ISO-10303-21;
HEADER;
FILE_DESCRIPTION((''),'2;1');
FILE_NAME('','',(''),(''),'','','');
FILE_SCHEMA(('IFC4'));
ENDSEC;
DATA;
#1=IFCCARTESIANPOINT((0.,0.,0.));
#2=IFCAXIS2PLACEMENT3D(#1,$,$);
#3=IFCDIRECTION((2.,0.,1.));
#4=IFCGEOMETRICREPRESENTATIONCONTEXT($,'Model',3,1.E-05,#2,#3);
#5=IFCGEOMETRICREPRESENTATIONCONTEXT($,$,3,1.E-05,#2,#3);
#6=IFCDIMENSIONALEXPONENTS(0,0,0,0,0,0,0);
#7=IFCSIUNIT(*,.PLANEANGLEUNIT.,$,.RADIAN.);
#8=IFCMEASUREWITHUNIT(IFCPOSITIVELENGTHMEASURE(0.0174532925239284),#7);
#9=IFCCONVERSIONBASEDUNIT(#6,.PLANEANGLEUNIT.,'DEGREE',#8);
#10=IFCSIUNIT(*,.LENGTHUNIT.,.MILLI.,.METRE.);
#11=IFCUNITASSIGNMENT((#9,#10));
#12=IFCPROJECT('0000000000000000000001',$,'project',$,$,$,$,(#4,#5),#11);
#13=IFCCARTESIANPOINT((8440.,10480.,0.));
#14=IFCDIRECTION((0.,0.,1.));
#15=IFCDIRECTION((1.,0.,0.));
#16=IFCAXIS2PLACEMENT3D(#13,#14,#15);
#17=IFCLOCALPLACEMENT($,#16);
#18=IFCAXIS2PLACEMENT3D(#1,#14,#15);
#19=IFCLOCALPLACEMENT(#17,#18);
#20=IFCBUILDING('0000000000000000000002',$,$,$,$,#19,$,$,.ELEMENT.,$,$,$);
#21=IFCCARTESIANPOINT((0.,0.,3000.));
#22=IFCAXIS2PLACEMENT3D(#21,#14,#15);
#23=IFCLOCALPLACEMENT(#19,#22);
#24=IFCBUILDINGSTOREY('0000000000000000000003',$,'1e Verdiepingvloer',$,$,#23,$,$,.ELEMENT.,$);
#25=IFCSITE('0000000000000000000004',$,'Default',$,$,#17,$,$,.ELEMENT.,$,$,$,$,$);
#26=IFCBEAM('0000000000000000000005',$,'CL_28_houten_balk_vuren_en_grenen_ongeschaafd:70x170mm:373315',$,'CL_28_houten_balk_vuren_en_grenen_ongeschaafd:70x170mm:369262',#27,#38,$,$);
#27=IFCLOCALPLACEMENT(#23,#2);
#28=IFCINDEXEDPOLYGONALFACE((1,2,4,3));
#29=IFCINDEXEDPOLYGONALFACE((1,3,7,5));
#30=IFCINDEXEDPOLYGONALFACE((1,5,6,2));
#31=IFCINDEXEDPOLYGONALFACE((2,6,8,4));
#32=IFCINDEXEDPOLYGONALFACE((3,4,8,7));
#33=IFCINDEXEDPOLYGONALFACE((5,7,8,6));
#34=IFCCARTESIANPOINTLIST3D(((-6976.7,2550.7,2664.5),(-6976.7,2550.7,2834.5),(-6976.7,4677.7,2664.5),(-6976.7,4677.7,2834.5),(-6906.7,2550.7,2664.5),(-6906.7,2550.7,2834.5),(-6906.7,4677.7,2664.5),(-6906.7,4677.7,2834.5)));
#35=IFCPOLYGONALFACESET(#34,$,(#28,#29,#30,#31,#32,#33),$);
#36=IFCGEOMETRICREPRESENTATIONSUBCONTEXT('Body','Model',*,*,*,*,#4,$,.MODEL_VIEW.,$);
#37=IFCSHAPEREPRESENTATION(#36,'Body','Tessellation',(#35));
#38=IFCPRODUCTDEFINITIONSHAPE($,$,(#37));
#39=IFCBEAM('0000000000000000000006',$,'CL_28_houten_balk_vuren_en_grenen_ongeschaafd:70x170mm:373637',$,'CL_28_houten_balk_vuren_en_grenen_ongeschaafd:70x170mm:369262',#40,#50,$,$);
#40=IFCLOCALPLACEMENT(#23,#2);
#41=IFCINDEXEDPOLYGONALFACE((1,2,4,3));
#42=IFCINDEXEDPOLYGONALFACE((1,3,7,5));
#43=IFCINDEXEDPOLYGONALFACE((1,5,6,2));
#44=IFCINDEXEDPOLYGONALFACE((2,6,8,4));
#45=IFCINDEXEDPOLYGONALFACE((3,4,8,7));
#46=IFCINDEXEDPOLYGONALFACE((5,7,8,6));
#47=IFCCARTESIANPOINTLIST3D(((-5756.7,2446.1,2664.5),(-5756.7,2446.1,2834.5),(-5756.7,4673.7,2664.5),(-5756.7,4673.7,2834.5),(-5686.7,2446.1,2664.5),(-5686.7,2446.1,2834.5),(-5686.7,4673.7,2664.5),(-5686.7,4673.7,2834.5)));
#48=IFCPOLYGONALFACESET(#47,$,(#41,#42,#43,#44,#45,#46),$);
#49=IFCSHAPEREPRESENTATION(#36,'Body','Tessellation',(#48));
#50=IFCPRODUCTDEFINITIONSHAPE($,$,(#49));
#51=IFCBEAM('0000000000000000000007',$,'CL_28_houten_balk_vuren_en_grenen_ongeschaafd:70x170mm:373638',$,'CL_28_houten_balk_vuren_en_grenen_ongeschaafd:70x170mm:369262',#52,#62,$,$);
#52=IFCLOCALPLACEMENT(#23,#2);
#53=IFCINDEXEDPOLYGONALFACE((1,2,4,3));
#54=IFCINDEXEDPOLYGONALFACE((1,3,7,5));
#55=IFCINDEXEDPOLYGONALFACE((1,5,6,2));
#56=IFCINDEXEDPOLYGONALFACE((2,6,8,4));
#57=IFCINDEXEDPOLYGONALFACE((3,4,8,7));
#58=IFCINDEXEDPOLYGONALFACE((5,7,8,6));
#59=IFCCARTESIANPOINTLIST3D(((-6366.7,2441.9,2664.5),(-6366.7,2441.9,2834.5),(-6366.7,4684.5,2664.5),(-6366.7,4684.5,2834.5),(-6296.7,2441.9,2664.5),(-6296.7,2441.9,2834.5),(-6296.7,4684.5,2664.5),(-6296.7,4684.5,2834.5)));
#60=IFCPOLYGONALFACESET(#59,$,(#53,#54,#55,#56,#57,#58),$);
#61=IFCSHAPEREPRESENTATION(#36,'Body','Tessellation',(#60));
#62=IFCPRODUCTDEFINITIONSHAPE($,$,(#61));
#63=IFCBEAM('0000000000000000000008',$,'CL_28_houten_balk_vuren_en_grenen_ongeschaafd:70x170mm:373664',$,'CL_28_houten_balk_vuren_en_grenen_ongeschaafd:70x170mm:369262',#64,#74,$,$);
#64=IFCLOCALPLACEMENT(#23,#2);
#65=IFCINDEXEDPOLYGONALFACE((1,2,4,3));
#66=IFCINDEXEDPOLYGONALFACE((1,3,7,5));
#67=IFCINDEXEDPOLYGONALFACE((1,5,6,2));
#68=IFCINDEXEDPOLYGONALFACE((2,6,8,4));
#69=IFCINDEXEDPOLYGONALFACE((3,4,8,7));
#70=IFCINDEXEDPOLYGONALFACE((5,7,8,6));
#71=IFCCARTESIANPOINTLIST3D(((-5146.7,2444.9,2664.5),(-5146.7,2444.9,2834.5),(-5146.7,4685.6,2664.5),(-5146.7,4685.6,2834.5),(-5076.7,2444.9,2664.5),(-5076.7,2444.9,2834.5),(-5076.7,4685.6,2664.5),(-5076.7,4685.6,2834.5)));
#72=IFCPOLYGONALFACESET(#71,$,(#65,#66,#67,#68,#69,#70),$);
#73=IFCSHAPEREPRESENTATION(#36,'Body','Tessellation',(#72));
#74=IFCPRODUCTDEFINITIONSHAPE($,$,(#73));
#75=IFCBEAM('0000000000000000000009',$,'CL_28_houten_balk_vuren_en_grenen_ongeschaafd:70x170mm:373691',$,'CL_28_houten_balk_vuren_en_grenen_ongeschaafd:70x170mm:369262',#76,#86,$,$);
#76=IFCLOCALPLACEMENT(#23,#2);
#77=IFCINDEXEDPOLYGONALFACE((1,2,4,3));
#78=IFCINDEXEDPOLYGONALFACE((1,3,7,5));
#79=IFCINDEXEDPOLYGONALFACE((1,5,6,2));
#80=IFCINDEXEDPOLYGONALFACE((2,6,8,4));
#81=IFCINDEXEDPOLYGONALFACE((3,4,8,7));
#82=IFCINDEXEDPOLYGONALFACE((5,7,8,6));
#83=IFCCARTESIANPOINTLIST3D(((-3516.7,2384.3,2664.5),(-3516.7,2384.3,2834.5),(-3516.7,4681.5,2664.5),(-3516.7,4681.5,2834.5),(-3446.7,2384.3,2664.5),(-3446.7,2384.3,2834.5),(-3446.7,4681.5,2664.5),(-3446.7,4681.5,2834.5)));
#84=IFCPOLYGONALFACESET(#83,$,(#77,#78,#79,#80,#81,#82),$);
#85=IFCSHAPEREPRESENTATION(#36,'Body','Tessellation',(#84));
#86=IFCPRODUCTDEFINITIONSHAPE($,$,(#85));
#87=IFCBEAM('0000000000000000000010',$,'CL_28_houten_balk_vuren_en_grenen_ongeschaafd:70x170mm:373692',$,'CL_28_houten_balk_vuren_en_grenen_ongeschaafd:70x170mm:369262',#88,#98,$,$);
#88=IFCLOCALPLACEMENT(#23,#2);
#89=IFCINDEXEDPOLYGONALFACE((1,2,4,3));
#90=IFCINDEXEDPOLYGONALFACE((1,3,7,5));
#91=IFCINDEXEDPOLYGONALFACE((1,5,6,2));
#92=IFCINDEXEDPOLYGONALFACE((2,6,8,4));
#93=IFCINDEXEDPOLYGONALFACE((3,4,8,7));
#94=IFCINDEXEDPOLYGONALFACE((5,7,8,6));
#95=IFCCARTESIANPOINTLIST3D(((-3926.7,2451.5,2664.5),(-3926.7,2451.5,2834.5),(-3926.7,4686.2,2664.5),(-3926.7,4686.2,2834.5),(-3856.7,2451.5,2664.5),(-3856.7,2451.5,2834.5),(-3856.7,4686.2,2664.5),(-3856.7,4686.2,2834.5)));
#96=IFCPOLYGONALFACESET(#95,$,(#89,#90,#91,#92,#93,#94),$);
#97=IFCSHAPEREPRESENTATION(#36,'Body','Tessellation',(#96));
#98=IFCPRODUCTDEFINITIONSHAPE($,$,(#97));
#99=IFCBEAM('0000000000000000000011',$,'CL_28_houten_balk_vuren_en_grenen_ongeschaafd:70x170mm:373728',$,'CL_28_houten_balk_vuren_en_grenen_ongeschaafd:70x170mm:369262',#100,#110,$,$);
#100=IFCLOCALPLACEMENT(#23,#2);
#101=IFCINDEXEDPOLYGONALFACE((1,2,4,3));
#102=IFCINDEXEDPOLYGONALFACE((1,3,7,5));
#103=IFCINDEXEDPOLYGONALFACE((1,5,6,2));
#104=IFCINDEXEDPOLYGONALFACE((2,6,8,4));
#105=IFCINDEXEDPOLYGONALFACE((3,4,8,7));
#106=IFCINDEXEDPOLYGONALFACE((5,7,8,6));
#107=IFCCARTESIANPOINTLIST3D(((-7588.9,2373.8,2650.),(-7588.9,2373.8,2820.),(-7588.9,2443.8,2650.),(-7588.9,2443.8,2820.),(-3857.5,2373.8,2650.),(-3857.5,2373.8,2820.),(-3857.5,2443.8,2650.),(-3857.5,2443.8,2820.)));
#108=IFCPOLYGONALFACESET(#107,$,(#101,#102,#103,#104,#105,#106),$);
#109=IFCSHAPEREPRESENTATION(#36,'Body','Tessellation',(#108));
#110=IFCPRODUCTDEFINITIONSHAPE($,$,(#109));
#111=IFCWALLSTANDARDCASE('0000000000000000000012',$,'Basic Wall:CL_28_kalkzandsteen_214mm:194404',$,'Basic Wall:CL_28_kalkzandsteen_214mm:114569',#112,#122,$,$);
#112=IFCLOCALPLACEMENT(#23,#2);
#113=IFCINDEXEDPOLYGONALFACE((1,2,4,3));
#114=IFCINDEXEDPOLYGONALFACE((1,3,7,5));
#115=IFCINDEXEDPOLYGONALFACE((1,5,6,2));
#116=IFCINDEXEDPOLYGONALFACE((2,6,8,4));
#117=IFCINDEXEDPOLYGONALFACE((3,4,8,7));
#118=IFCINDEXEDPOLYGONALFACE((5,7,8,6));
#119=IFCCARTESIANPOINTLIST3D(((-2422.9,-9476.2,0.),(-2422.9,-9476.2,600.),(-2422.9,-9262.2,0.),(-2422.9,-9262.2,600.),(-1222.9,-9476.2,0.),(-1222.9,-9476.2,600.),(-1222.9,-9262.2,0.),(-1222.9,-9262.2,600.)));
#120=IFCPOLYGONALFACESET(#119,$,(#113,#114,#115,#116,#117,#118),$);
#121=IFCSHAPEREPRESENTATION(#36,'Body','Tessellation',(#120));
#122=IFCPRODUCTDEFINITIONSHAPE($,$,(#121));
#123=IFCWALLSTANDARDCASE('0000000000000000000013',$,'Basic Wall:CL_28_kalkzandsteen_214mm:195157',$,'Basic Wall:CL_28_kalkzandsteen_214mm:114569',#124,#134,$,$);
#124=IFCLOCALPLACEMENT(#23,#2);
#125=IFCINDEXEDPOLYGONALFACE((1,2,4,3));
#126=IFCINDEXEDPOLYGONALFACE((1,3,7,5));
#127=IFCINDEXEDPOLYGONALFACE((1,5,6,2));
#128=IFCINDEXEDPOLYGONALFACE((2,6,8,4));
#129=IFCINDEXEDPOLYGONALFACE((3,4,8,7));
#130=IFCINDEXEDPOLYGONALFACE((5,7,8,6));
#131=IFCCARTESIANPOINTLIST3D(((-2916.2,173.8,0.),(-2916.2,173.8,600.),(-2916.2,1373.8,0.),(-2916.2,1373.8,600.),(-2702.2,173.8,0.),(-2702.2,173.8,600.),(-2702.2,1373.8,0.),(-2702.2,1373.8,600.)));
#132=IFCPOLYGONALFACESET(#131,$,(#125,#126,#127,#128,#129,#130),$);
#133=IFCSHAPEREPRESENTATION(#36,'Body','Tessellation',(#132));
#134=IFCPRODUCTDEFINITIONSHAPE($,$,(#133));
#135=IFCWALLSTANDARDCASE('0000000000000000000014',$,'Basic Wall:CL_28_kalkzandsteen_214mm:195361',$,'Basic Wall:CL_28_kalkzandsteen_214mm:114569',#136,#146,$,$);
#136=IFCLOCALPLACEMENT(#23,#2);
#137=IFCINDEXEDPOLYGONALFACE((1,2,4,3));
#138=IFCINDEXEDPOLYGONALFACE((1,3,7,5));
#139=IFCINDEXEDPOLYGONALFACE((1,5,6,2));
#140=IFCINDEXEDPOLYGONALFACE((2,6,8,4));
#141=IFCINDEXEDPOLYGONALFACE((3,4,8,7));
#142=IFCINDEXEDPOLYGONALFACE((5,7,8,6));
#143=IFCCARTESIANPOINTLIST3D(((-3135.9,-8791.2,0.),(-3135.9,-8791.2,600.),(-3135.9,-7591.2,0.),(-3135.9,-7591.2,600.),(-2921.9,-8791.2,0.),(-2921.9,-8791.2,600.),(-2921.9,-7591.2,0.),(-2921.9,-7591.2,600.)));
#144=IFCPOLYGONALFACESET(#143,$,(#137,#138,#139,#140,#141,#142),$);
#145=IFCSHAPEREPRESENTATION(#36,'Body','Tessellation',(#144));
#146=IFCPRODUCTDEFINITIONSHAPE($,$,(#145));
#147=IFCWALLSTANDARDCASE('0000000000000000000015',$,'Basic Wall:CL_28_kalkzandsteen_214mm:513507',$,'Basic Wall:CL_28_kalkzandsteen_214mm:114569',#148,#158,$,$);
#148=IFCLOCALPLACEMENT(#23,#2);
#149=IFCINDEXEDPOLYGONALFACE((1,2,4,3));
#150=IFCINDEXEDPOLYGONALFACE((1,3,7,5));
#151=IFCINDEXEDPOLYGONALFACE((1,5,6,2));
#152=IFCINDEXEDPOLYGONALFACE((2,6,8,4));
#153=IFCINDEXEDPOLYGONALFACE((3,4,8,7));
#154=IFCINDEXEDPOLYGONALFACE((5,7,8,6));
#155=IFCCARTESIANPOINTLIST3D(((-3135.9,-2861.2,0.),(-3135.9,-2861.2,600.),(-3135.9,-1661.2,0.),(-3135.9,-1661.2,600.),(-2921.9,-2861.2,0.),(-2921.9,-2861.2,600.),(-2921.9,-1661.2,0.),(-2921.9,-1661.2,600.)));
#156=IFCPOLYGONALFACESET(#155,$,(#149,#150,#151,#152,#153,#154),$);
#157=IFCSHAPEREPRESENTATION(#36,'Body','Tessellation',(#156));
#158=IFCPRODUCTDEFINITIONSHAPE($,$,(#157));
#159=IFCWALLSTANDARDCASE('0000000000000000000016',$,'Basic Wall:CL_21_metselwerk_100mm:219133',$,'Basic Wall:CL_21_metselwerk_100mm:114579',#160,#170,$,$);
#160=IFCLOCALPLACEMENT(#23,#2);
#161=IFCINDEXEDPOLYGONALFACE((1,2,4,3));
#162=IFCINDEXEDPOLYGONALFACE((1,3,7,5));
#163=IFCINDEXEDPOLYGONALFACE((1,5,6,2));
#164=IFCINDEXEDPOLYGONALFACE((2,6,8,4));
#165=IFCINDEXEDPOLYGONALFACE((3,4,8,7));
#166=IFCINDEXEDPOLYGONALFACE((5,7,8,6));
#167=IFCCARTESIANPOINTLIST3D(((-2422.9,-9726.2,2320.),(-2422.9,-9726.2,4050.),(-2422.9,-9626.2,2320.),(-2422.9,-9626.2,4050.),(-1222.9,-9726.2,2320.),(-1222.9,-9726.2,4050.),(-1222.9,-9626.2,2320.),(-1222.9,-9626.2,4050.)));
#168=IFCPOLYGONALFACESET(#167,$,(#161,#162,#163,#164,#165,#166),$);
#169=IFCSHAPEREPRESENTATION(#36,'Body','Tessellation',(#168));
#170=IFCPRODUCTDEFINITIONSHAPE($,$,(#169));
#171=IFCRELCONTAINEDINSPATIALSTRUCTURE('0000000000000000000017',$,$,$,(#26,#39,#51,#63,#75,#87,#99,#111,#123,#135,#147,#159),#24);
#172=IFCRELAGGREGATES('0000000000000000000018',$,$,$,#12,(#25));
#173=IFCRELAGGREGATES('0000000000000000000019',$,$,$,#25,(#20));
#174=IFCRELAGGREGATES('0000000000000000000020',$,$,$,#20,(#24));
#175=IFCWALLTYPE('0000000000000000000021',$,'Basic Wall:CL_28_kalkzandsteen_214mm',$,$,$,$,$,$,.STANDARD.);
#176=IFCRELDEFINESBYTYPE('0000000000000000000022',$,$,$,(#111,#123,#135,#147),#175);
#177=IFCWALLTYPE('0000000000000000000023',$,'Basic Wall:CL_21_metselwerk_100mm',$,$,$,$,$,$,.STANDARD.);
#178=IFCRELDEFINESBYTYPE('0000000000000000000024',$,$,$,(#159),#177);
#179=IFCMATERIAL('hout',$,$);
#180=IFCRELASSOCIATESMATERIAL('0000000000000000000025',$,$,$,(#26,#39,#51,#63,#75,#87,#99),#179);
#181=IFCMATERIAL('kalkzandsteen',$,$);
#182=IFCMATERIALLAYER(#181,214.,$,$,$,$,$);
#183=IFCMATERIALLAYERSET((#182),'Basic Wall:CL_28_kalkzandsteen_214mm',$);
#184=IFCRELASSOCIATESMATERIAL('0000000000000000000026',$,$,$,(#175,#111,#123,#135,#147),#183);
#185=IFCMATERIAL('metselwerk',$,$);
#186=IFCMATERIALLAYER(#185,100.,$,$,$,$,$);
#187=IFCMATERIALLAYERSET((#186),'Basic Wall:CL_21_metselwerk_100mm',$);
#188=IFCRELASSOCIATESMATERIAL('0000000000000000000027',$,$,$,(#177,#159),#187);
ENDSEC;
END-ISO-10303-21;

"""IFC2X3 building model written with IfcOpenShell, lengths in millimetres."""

from ifc_helpers import new_model, entity, si_unit, converted_unit, direction, frame, frame_2d, origin, origin_with_axes, place, context, subcontext, project, spatial, rectangle, extrude, source, transform, mapped, material, layer, layer_set, layer_usage, type_object, element, save


model = new_model("IFC2X3")

# Units and contexts
model_context = context("Model", 3, precision=1e-05, world=origin(), true_north=direction((2.0, 0.0, 1.0)))
context_of_model = context(None, 3, precision=1e-05, world=origin(), true_north=direction((2.0, 0.0, 1.0)))
body_context = subcontext(model_context, "Body", "Model", "MODEL_VIEW")
ifc_project = project(units=[converted_unit("PLANEANGLEUNIT", "DEGREE", entity("IfcPositiveLengthMeasure", 0.0174532925239284), si_unit("PLANEANGLEUNIT", "RADIAN"), dimensions=[0, 0, 0, 0, 0, 0, 0]), si_unit("LENGTHUNIT", "METRE", prefix="MILLI")], contexts=[model_context, context_of_model])

# Site, building, storey
site_placement = place(None, frame((8440.0, 10480.0, 0.0), z_axis=(0.0, 0.0, 1.0), x_axis=(1.0, 0.0, 0.0)))
site = spatial("IfcSite", under=ifc_project, at=site_placement, Name="Default", CompositionType="ELEMENT")
building_placement = place(site_placement, origin_with_axes())
building = spatial("IfcBuilding", under=site, at=building_placement, CompositionType="ELEMENT")
storey_placement = place(building_placement, frame((0.0, 0.0, 3000.0), z_axis=(0.0, 0.0, 1.0), x_axis=(1.0, 0.0, 0.0)))
storey = spatial("IfcBuildingStorey", under=building, at=storey_placement, Name="1e Verdiepingvloer", CompositionType="ELEMENT")

# Beams
ifc_material_1 = material(Name="hout")
beam_1_placement = place(storey_placement, frame((-6941.7, 2480.8, 2834.5), z_axis=(0.0, 0.0, 1.0), x_axis=(0.0, 1.0, 0.0)))
element("IfcBeam", 1, at=beam_1_placement, inside=storey, material=ifc_material_1, Name="CL_28_houten_balk_vuren_en_grenen_ongeschaafd:70x170mm:373315", ObjectType="CL_28_houten_balk_vuren_en_grenen_ongeschaafd:70x170mm:369262", context=body_context, shape_type="SweptSolid", body=[
    extrude(rectangle(XDim=170.0, YDim=70.0, at=frame_2d((0.0, 0.0), x_axis=(1.0, 0.0))), frame((69.9, 0.0, -85.0), z_axis=(1.0, 0.0, 0.0), x_axis=(0.0, 0.0, -1.0)), (0.0, 0.0, 1.0), 2127.0),
])
beam_2_placement = place(storey_placement, frame((-5721.7, 2480.8, 2834.5), z_axis=(0.0, 0.0, 1.0), x_axis=(0.0, 1.0, 0.0)))
element("IfcBeam", 2, at=beam_2_placement, inside=storey, material=ifc_material_1, Name="CL_28_houten_balk_vuren_en_grenen_ongeschaafd:70x170mm:373637", ObjectType="CL_28_houten_balk_vuren_en_grenen_ongeschaafd:70x170mm:369262", context=body_context, shape_type="SweptSolid", body=[
    extrude(rectangle(XDim=170.0, YDim=70.0, at=frame_2d((0.0, 0.0), x_axis=(1.0, 0.0))), frame((-34.7, 0.0, -85.0), z_axis=(1.0, 0.0, 0.0), x_axis=(0.0, 0.0, -1.0)), (0.0, 0.0, 1.0), 2227.7),
])
beam_3_placement = place(storey_placement, frame((-6331.7, 2480.8, 2834.5), z_axis=(0.0, 0.0, 1.0), x_axis=(0.0, 1.0, 0.0)))
element("IfcBeam", 3, at=beam_3_placement, inside=storey, material=ifc_material_1, Name="CL_28_houten_balk_vuren_en_grenen_ongeschaafd:70x170mm:373638", ObjectType="CL_28_houten_balk_vuren_en_grenen_ongeschaafd:70x170mm:369262", context=body_context, shape_type="SweptSolid", body=[
    extrude(rectangle(XDim=170.0, YDim=70.0, at=frame_2d((0.0, 0.0), x_axis=(1.0, 0.0))), frame((-38.9, 0.0, -85.0), z_axis=(1.0, 0.0, 0.0), x_axis=(0.0, 0.0, -1.0)), (0.0, 0.0, 1.0), 2242.6),
])
beam_4_placement = place(storey_placement, frame((-5111.7, 2480.8, 2834.5), z_axis=(0.0, 0.0, 1.0), x_axis=(0.0, 1.0, 0.0)))
element("IfcBeam", 4, at=beam_4_placement, inside=storey, material=ifc_material_1, Name="CL_28_houten_balk_vuren_en_grenen_ongeschaafd:70x170mm:373664", ObjectType="CL_28_houten_balk_vuren_en_grenen_ongeschaafd:70x170mm:369262", context=body_context, shape_type="SweptSolid", body=[
    extrude(rectangle(XDim=170.0, YDim=70.0, at=frame_2d((0.0, 0.0), x_axis=(1.0, 0.0))), frame((-35.9, 0.0, -85.0), z_axis=(1.0, 0.0, 0.0), x_axis=(0.0, 0.0, -1.0)), (0.0, 0.0, 1.0), 2240.7),
])
beam_5_placement = place(storey_placement, frame((-3481.7, 2373.8, 2834.5), z_axis=(0.0, 0.0, 1.0), x_axis=(0.0, 1.0, 0.0)))
element("IfcBeam", 5, at=beam_5_placement, inside=storey, material=ifc_material_1, Name="CL_28_houten_balk_vuren_en_grenen_ongeschaafd:70x170mm:373691", ObjectType="CL_28_houten_balk_vuren_en_grenen_ongeschaafd:70x170mm:369262", context=body_context, shape_type="SweptSolid", body=[
    extrude(rectangle(XDim=170.0, YDim=70.0, at=frame_2d((0.0, 0.0), x_axis=(1.0, 0.0))), frame((10.5, 0.0, -85.0), z_axis=(1.0, 0.0, 0.0), x_axis=(0.0, 0.0, -1.0)), (0.0, 0.0, 1.0), 2297.2),
])
beam_6_placement = place(storey_placement, frame((-3891.7, 2441.0, 2834.5), z_axis=(0.0, 0.0, 1.0), x_axis=(0.0, 1.0, 0.0)))
element("IfcBeam", 6, at=beam_6_placement, inside=storey, material=ifc_material_1, Name="CL_28_houten_balk_vuren_en_grenen_ongeschaafd:70x170mm:373692", ObjectType="CL_28_houten_balk_vuren_en_grenen_ongeschaafd:70x170mm:369262", context=body_context, shape_type="SweptSolid", body=[
    extrude(rectangle(XDim=170.0, YDim=70.0, at=frame_2d((0.0, 0.0), x_axis=(1.0, 0.0))), frame((10.5, 0.0, -85.0), z_axis=(1.0, 0.0, 0.0), x_axis=(0.0, 0.0, -1.0)), (0.0, 0.0, 1.0), 2234.7),
])
beam_7_placement = place(storey_placement, frame((-7148.9, 2408.8, 2820.0), z_axis=(0.0, 0.0, 1.0), x_axis=(1.0, 0.0, 0.0)))
element("IfcBeam", 7, at=beam_7_placement, inside=storey, material=ifc_material_1, Name="CL_28_houten_balk_vuren_en_grenen_ongeschaafd:70x170mm:373728", ObjectType="CL_28_houten_balk_vuren_en_grenen_ongeschaafd:70x170mm:369262", context=body_context, shape_type="SweptSolid", body=[
    extrude(rectangle(XDim=170.0, YDim=70.0, at=frame_2d((0.0, 0.0), x_axis=(1.0, 0.0))), frame((-440.0, 0.0, -85.0), z_axis=(1.0, 0.0, 0.0), x_axis=(0.0, 0.0, -1.0)), (0.0, 0.0, 1.0), 3731.4),
])

# Walls
ifc_material_2 = material(Name="kalkzandsteen")
ifc_layer_1 = layer(ifc_material_2, 214.0)
ifc_layer_set_1 = layer_set([ifc_layer_1], Name="Basic Wall:CL_28_kalkzandsteen_214mm")
ifc_layer_usage_1 = layer_usage(ifc_layer_set_1, "AXIS2", "NEGATIVE", 107.0)
wall_type_1 = type_object("IfcWallType", Name="Basic Wall:CL_28_kalkzandsteen_214mm", PredefinedType="STANDARD", material=ifc_layer_set_1)
shared_shape_1 = source(origin(), body_context, "Body", "SweptSolid", [
    extrude(rectangle(XDim=1200.0, YDim=214.0, at=frame_2d((600.0, 0.0), x_axis=(-1.0, 0.0))), origin(), (0.0, 0.0, 1.0), 600.0),
])
wall_1_placement = place(storey_placement, frame((-2422.9, -9369.2, 0.0), z_axis=(0.0, 0.0, 1.0), x_axis=(1.0, 0.0, 0.0)))
element("IfcWallStandardCase", 8, at=wall_1_placement, inside=storey, type_object=wall_type_1, material=ifc_layer_usage_1, Name="Basic Wall:CL_28_kalkzandsteen_214mm:194404", ObjectType="Basic Wall:CL_28_kalkzandsteen_214mm:114569", context=body_context, shape_type="MappedRepresentation", body=[
    mapped(shared_shape_1, transform((0.0, 0.0, 0.0))),
])
ifc_layer_usage_2 = layer_usage(ifc_layer_set_1, "AXIS2", "NEGATIVE", 107.0)
wall_2_placement = place(storey_placement, frame((-2809.2, 1373.8, 0.0), z_axis=(0.0, 0.0, 1.0), x_axis=(0.0, -1.0, 0.0)))
element("IfcWallStandardCase", 9, at=wall_2_placement, inside=storey, type_object=wall_type_1, material=ifc_layer_usage_2, Name="Basic Wall:CL_28_kalkzandsteen_214mm:195157", ObjectType="Basic Wall:CL_28_kalkzandsteen_214mm:114569", context=body_context, shape_type="MappedRepresentation", body=[
    mapped(shared_shape_1, transform((0.0, 0.0, 0.0))),
])
ifc_layer_usage_3 = layer_usage(ifc_layer_set_1, "AXIS2", "NEGATIVE", 107.0)
wall_3_placement = place(storey_placement, frame((-3028.9, -7591.2, 0.0), z_axis=(0.0, 0.0, 1.0), x_axis=(0.0, -1.0, 0.0)))
element("IfcWallStandardCase", 10, at=wall_3_placement, inside=storey, type_object=wall_type_1, material=ifc_layer_usage_3, Name="Basic Wall:CL_28_kalkzandsteen_214mm:195361", ObjectType="Basic Wall:CL_28_kalkzandsteen_214mm:114569", context=body_context, shape_type="MappedRepresentation", body=[
    mapped(shared_shape_1, transform((0.0, 0.0, 0.0))),
])
ifc_layer_usage_4 = layer_usage(ifc_layer_set_1, "AXIS2", "NEGATIVE", 107.0)
wall_4_placement = place(storey_placement, frame((-3028.9, -1661.2, 0.0), z_axis=(0.0, 0.0, 1.0), x_axis=(0.0, -1.0, 0.0)))
element("IfcWallStandardCase", 11, at=wall_4_placement, inside=storey, type_object=wall_type_1, material=ifc_layer_usage_4, Name="Basic Wall:CL_28_kalkzandsteen_214mm:513507", ObjectType="Basic Wall:CL_28_kalkzandsteen_214mm:114569", context=body_context, shape_type="MappedRepresentation", body=[
    mapped(shared_shape_1, transform((0.0, 0.0, 0.0))),
])
ifc_material_3 = material(Name="metselwerk")
ifc_layer_2 = layer(ifc_material_3, 100.0)
ifc_layer_set_2 = layer_set([ifc_layer_2], Name="Basic Wall:CL_21_metselwerk_100mm")
ifc_layer_usage_5 = layer_usage(ifc_layer_set_2, "AXIS2", "NEGATIVE", 50.0)
wall_type_2 = type_object("IfcWallType", Name="Basic Wall:CL_21_metselwerk_100mm", PredefinedType="STANDARD", material=ifc_layer_set_2)
shared_shape_2 = source(origin(), body_context, "Body", "SweptSolid", [
    extrude(rectangle(XDim=1200.0, YDim=100.0, at=frame_2d((600.0, 0.0), x_axis=(-1.0, 0.0))), origin(), (0.0, 0.0, 1.0), 1730.0),
])
wall_5_placement = place(storey_placement, frame((-2422.9, -9676.2, 2320.0), z_axis=(0.0, 0.0, 1.0), x_axis=(1.0, 0.0, 0.0)))
element("IfcWallStandardCase", 12, at=wall_5_placement, inside=storey, type_object=wall_type_2, material=ifc_layer_usage_5, Name="Basic Wall:CL_21_metselwerk_100mm:219133", ObjectType="Basic Wall:CL_21_metselwerk_100mm:114579", context=body_context, shape_type="MappedRepresentation", body=[
    mapped(shared_shape_2, transform((0.0, 0.0, 0.0))),
])

save(model, "model.ifc")
